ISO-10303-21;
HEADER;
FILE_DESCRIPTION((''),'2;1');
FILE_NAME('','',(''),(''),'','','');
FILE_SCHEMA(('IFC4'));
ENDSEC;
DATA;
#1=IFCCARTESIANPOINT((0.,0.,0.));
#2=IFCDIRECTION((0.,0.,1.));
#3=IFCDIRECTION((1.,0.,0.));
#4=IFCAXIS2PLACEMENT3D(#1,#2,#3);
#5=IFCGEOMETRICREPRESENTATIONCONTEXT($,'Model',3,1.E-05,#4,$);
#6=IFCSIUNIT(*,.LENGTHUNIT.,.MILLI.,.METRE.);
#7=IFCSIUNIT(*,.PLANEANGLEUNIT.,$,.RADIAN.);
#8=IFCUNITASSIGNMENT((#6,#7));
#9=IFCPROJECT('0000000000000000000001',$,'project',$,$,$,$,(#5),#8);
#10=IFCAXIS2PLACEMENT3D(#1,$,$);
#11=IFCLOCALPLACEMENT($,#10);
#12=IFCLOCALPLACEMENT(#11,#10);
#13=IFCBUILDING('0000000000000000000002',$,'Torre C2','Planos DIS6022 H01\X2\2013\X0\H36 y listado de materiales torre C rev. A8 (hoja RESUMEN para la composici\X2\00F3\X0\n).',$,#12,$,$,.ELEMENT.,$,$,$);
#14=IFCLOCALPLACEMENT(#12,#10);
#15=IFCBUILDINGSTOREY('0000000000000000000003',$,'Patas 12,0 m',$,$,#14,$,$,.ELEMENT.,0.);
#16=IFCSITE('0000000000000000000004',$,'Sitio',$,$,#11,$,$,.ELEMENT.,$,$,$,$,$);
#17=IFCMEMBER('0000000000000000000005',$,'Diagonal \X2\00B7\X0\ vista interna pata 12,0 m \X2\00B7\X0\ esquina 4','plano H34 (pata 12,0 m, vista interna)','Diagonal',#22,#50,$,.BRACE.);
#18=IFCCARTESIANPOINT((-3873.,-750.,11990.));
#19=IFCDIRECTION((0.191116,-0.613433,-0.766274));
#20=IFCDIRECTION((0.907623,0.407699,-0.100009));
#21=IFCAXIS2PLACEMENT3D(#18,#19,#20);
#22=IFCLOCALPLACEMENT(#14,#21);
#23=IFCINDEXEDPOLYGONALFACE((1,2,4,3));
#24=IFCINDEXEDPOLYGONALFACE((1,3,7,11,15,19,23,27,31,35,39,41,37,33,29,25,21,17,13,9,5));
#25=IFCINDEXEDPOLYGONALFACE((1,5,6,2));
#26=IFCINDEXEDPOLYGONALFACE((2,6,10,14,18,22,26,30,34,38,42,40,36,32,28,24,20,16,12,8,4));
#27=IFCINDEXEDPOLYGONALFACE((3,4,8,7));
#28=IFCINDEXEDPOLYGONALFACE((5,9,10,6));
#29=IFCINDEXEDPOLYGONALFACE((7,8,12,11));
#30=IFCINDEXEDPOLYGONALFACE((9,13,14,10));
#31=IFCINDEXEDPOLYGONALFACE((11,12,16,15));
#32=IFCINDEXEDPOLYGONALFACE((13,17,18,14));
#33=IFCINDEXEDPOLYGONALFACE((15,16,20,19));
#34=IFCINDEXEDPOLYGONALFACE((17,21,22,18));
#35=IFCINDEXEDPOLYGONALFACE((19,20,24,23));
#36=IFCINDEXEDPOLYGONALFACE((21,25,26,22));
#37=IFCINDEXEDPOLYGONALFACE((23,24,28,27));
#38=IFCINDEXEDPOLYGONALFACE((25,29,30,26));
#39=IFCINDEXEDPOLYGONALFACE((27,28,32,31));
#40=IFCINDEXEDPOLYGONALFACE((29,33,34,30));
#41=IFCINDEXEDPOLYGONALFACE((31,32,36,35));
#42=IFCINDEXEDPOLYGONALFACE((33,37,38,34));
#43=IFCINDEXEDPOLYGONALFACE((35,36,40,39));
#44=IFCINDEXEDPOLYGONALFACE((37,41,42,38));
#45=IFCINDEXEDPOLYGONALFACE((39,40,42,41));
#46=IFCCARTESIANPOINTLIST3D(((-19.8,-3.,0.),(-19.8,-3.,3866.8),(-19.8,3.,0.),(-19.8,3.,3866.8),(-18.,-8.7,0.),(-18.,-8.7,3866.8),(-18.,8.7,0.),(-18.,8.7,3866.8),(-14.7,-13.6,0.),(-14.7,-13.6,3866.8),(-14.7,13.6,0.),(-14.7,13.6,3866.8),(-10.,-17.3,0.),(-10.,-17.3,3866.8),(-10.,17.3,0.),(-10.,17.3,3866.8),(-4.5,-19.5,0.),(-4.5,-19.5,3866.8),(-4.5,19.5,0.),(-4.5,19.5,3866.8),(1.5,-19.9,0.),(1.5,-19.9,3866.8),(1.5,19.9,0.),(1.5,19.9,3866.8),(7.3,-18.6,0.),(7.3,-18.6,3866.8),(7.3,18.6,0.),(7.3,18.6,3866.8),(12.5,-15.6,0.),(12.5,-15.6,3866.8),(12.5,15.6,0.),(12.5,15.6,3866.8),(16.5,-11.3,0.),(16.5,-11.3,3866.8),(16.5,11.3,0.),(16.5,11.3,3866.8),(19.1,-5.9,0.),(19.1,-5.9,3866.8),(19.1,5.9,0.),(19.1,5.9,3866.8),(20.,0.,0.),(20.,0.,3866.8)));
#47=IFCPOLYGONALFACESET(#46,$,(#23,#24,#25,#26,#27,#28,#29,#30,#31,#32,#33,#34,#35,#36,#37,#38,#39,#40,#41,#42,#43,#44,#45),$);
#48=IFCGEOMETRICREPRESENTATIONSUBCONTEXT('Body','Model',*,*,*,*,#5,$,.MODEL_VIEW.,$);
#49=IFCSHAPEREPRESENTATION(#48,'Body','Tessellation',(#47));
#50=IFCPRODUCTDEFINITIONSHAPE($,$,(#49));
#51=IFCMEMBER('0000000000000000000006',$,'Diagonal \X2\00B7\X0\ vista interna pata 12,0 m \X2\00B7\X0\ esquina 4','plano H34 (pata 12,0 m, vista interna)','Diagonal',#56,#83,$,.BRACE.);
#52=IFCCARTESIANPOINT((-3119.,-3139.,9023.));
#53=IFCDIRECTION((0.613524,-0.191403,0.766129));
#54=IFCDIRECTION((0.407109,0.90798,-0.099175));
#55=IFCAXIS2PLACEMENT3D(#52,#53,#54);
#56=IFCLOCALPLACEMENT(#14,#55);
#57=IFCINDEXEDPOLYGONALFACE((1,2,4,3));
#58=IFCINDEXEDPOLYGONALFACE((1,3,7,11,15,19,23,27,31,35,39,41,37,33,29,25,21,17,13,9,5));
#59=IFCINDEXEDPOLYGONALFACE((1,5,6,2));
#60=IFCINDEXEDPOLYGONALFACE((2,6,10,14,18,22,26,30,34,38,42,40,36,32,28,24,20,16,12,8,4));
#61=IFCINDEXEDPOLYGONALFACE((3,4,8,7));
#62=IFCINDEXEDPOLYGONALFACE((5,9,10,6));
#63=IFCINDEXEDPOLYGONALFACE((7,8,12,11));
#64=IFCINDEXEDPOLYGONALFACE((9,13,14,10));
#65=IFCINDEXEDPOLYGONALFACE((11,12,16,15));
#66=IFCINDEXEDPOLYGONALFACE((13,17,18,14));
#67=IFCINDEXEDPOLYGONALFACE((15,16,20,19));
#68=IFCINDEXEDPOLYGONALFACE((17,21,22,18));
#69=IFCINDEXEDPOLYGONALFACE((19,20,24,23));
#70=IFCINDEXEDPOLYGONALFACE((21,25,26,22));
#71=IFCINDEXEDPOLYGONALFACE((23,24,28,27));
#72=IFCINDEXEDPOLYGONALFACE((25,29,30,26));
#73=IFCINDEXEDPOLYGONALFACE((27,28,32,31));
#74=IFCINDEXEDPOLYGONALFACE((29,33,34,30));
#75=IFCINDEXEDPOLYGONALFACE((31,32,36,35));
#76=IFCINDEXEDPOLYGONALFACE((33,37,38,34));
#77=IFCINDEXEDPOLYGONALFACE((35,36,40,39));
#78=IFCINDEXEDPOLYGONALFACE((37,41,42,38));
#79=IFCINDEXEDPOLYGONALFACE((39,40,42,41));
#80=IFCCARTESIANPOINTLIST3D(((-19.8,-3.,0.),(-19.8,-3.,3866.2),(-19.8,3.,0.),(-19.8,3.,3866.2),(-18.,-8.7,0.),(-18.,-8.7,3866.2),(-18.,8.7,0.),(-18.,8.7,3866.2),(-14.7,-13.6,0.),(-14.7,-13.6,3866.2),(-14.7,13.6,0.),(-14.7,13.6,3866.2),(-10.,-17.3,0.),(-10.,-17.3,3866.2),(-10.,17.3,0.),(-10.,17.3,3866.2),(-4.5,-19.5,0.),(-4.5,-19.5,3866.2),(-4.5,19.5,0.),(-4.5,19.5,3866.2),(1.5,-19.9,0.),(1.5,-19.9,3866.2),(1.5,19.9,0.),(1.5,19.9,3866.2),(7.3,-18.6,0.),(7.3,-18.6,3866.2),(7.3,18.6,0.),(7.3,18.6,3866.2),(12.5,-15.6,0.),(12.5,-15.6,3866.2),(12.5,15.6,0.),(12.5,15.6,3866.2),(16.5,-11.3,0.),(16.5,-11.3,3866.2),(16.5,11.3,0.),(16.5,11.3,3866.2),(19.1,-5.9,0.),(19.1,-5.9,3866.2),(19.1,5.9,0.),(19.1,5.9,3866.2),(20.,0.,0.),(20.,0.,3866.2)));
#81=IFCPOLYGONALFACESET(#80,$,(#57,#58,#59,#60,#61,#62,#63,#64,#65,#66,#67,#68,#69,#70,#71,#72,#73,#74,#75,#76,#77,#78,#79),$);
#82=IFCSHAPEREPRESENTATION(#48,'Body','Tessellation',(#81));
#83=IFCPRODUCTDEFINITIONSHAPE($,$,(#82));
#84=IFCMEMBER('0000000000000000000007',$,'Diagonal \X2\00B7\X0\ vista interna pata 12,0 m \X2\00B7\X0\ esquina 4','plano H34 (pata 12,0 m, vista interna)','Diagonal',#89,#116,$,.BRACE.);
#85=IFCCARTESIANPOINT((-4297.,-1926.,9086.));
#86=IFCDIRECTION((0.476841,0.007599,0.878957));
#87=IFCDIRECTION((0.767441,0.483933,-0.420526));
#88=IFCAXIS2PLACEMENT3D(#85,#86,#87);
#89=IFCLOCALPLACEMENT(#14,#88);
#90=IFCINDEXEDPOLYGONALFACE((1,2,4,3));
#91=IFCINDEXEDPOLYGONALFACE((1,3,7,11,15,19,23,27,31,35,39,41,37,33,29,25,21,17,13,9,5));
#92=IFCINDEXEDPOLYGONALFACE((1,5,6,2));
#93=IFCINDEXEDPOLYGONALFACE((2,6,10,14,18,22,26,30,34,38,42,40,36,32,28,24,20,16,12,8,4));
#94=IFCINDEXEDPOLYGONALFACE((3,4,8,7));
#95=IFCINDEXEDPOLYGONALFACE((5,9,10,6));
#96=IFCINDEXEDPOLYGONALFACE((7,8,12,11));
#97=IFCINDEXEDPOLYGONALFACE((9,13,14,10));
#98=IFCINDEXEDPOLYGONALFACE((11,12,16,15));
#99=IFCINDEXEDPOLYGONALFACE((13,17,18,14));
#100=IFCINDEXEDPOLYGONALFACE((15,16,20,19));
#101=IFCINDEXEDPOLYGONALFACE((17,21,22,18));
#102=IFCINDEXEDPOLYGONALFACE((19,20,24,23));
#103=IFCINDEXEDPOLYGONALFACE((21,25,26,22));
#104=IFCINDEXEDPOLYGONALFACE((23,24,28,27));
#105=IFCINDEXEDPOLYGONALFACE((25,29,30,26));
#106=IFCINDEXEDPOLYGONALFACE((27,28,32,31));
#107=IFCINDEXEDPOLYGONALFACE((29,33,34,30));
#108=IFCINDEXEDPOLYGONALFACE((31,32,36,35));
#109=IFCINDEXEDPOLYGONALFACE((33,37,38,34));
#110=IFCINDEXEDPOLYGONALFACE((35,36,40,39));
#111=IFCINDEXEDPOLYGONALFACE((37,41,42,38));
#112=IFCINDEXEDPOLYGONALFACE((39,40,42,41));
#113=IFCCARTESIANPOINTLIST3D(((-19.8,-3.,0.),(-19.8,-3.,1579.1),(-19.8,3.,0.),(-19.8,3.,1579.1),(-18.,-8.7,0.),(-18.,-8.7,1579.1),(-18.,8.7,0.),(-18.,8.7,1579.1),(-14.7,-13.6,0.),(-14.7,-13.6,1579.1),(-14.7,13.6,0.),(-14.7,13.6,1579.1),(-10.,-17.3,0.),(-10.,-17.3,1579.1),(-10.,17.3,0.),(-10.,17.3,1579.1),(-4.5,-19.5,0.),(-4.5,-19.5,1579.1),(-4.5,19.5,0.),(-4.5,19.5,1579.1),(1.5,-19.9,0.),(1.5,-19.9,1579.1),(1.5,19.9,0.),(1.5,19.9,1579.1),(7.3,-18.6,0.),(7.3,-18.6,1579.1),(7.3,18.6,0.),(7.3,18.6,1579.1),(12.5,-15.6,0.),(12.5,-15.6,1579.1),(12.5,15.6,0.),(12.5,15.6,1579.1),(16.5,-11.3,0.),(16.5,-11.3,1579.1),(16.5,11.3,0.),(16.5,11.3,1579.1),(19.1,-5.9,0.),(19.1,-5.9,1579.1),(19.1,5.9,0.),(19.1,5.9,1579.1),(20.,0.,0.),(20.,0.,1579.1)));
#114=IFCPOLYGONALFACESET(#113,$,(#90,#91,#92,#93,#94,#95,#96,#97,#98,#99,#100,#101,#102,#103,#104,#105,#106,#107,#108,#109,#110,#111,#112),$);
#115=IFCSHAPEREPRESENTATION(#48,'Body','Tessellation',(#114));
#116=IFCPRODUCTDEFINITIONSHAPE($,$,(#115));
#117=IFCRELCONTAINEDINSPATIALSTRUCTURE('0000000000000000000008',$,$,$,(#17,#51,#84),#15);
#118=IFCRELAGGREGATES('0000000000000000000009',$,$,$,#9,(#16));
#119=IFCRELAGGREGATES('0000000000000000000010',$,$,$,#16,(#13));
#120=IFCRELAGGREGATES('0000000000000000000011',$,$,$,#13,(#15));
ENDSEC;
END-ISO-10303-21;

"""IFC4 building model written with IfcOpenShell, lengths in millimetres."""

from ifc_helpers import new_model, si_unit, frame, origin, origin_with_axes, place, context, subcontext, project, spatial, circle, extrude, element, save


model = new_model("IFC4")

# Units and contexts
model_context = context("Model", 3, precision=1e-05, world=origin_with_axes())
body_context = subcontext(model_context, "Body", "Model", "MODEL_VIEW")
ifc_project = project(units=[si_unit("LENGTHUNIT", "METRE", prefix="MILLI"), si_unit("PLANEANGLEUNIT", "RADIAN")], contexts=[model_context])

# Site, building, storey
site_placement = place(None, origin())
site = spatial("IfcSite", under=ifc_project, at=site_placement, Name="Sitio", CompositionType="ELEMENT")
building_placement = place(site_placement, origin())
building = spatial("IfcBuilding", under=site, at=building_placement, Name="Torre C2", Description="Planos DIS6022 H01–H36 y listado de materiales torre C rev. A8 (hoja RESUMEN para la composición).", CompositionType="ELEMENT")
storey_placement = place(building_placement, origin())
storey = spatial("IfcBuildingStorey", under=building, at=storey_placement, Name="Patas 12,0 m", CompositionType="ELEMENT", Elevation=0.0)

# Members
member_1_placement = place(storey_placement, frame((-3873.0, -750.0, 11990.0), z_axis=(0.191116, -0.613433, -0.766274), x_axis=(0.907623, 0.407699, -0.100009)))
element("IfcMember", 1, at=member_1_placement, inside=storey, Name="Diagonal · vista interna pata 12,0 m · esquina 4", Description="plano H34 (pata 12,0 m, vista interna)", ObjectType="Diagonal", PredefinedType="BRACE", context=body_context, shape_type="SweptSolid", body=[
    extrude(circle(Radius=20.0), None, (0.0, 0.0, 1.0), 3866.8),
])
member_2_placement = place(storey_placement, frame((-3119.0, -3139.0, 9023.0), z_axis=(0.613524, -0.191403, 0.766129), x_axis=(0.407109, 0.90798, -0.099175)))
element("IfcMember", 2, at=member_2_placement, inside=storey, Name="Diagonal · vista interna pata 12,0 m · esquina 4", Description="plano H34 (pata 12,0 m, vista interna)", ObjectType="Diagonal", PredefinedType="BRACE", context=body_context, shape_type="SweptSolid", body=[
    extrude(circle(Radius=20.0), None, (0.0, 0.0, 1.0), 3866.2),
])
member_3_placement = place(storey_placement, frame((-4297.0, -1926.0, 9086.0), z_axis=(0.476841, 0.007599, 0.878957), x_axis=(0.767441, 0.483933, -0.420526)))
element("IfcMember", 3, at=member_3_placement, inside=storey, Name="Diagonal · vista interna pata 12,0 m · esquina 4", Description="plano H34 (pata 12,0 m, vista interna)", ObjectType="Diagonal", PredefinedType="BRACE", context=body_context, shape_type="SweptSolid", body=[
    extrude(circle(Radius=20.0), None, (0.0, 0.0, 1.0), 1579.1),
])

save(model, "model.ifc")
